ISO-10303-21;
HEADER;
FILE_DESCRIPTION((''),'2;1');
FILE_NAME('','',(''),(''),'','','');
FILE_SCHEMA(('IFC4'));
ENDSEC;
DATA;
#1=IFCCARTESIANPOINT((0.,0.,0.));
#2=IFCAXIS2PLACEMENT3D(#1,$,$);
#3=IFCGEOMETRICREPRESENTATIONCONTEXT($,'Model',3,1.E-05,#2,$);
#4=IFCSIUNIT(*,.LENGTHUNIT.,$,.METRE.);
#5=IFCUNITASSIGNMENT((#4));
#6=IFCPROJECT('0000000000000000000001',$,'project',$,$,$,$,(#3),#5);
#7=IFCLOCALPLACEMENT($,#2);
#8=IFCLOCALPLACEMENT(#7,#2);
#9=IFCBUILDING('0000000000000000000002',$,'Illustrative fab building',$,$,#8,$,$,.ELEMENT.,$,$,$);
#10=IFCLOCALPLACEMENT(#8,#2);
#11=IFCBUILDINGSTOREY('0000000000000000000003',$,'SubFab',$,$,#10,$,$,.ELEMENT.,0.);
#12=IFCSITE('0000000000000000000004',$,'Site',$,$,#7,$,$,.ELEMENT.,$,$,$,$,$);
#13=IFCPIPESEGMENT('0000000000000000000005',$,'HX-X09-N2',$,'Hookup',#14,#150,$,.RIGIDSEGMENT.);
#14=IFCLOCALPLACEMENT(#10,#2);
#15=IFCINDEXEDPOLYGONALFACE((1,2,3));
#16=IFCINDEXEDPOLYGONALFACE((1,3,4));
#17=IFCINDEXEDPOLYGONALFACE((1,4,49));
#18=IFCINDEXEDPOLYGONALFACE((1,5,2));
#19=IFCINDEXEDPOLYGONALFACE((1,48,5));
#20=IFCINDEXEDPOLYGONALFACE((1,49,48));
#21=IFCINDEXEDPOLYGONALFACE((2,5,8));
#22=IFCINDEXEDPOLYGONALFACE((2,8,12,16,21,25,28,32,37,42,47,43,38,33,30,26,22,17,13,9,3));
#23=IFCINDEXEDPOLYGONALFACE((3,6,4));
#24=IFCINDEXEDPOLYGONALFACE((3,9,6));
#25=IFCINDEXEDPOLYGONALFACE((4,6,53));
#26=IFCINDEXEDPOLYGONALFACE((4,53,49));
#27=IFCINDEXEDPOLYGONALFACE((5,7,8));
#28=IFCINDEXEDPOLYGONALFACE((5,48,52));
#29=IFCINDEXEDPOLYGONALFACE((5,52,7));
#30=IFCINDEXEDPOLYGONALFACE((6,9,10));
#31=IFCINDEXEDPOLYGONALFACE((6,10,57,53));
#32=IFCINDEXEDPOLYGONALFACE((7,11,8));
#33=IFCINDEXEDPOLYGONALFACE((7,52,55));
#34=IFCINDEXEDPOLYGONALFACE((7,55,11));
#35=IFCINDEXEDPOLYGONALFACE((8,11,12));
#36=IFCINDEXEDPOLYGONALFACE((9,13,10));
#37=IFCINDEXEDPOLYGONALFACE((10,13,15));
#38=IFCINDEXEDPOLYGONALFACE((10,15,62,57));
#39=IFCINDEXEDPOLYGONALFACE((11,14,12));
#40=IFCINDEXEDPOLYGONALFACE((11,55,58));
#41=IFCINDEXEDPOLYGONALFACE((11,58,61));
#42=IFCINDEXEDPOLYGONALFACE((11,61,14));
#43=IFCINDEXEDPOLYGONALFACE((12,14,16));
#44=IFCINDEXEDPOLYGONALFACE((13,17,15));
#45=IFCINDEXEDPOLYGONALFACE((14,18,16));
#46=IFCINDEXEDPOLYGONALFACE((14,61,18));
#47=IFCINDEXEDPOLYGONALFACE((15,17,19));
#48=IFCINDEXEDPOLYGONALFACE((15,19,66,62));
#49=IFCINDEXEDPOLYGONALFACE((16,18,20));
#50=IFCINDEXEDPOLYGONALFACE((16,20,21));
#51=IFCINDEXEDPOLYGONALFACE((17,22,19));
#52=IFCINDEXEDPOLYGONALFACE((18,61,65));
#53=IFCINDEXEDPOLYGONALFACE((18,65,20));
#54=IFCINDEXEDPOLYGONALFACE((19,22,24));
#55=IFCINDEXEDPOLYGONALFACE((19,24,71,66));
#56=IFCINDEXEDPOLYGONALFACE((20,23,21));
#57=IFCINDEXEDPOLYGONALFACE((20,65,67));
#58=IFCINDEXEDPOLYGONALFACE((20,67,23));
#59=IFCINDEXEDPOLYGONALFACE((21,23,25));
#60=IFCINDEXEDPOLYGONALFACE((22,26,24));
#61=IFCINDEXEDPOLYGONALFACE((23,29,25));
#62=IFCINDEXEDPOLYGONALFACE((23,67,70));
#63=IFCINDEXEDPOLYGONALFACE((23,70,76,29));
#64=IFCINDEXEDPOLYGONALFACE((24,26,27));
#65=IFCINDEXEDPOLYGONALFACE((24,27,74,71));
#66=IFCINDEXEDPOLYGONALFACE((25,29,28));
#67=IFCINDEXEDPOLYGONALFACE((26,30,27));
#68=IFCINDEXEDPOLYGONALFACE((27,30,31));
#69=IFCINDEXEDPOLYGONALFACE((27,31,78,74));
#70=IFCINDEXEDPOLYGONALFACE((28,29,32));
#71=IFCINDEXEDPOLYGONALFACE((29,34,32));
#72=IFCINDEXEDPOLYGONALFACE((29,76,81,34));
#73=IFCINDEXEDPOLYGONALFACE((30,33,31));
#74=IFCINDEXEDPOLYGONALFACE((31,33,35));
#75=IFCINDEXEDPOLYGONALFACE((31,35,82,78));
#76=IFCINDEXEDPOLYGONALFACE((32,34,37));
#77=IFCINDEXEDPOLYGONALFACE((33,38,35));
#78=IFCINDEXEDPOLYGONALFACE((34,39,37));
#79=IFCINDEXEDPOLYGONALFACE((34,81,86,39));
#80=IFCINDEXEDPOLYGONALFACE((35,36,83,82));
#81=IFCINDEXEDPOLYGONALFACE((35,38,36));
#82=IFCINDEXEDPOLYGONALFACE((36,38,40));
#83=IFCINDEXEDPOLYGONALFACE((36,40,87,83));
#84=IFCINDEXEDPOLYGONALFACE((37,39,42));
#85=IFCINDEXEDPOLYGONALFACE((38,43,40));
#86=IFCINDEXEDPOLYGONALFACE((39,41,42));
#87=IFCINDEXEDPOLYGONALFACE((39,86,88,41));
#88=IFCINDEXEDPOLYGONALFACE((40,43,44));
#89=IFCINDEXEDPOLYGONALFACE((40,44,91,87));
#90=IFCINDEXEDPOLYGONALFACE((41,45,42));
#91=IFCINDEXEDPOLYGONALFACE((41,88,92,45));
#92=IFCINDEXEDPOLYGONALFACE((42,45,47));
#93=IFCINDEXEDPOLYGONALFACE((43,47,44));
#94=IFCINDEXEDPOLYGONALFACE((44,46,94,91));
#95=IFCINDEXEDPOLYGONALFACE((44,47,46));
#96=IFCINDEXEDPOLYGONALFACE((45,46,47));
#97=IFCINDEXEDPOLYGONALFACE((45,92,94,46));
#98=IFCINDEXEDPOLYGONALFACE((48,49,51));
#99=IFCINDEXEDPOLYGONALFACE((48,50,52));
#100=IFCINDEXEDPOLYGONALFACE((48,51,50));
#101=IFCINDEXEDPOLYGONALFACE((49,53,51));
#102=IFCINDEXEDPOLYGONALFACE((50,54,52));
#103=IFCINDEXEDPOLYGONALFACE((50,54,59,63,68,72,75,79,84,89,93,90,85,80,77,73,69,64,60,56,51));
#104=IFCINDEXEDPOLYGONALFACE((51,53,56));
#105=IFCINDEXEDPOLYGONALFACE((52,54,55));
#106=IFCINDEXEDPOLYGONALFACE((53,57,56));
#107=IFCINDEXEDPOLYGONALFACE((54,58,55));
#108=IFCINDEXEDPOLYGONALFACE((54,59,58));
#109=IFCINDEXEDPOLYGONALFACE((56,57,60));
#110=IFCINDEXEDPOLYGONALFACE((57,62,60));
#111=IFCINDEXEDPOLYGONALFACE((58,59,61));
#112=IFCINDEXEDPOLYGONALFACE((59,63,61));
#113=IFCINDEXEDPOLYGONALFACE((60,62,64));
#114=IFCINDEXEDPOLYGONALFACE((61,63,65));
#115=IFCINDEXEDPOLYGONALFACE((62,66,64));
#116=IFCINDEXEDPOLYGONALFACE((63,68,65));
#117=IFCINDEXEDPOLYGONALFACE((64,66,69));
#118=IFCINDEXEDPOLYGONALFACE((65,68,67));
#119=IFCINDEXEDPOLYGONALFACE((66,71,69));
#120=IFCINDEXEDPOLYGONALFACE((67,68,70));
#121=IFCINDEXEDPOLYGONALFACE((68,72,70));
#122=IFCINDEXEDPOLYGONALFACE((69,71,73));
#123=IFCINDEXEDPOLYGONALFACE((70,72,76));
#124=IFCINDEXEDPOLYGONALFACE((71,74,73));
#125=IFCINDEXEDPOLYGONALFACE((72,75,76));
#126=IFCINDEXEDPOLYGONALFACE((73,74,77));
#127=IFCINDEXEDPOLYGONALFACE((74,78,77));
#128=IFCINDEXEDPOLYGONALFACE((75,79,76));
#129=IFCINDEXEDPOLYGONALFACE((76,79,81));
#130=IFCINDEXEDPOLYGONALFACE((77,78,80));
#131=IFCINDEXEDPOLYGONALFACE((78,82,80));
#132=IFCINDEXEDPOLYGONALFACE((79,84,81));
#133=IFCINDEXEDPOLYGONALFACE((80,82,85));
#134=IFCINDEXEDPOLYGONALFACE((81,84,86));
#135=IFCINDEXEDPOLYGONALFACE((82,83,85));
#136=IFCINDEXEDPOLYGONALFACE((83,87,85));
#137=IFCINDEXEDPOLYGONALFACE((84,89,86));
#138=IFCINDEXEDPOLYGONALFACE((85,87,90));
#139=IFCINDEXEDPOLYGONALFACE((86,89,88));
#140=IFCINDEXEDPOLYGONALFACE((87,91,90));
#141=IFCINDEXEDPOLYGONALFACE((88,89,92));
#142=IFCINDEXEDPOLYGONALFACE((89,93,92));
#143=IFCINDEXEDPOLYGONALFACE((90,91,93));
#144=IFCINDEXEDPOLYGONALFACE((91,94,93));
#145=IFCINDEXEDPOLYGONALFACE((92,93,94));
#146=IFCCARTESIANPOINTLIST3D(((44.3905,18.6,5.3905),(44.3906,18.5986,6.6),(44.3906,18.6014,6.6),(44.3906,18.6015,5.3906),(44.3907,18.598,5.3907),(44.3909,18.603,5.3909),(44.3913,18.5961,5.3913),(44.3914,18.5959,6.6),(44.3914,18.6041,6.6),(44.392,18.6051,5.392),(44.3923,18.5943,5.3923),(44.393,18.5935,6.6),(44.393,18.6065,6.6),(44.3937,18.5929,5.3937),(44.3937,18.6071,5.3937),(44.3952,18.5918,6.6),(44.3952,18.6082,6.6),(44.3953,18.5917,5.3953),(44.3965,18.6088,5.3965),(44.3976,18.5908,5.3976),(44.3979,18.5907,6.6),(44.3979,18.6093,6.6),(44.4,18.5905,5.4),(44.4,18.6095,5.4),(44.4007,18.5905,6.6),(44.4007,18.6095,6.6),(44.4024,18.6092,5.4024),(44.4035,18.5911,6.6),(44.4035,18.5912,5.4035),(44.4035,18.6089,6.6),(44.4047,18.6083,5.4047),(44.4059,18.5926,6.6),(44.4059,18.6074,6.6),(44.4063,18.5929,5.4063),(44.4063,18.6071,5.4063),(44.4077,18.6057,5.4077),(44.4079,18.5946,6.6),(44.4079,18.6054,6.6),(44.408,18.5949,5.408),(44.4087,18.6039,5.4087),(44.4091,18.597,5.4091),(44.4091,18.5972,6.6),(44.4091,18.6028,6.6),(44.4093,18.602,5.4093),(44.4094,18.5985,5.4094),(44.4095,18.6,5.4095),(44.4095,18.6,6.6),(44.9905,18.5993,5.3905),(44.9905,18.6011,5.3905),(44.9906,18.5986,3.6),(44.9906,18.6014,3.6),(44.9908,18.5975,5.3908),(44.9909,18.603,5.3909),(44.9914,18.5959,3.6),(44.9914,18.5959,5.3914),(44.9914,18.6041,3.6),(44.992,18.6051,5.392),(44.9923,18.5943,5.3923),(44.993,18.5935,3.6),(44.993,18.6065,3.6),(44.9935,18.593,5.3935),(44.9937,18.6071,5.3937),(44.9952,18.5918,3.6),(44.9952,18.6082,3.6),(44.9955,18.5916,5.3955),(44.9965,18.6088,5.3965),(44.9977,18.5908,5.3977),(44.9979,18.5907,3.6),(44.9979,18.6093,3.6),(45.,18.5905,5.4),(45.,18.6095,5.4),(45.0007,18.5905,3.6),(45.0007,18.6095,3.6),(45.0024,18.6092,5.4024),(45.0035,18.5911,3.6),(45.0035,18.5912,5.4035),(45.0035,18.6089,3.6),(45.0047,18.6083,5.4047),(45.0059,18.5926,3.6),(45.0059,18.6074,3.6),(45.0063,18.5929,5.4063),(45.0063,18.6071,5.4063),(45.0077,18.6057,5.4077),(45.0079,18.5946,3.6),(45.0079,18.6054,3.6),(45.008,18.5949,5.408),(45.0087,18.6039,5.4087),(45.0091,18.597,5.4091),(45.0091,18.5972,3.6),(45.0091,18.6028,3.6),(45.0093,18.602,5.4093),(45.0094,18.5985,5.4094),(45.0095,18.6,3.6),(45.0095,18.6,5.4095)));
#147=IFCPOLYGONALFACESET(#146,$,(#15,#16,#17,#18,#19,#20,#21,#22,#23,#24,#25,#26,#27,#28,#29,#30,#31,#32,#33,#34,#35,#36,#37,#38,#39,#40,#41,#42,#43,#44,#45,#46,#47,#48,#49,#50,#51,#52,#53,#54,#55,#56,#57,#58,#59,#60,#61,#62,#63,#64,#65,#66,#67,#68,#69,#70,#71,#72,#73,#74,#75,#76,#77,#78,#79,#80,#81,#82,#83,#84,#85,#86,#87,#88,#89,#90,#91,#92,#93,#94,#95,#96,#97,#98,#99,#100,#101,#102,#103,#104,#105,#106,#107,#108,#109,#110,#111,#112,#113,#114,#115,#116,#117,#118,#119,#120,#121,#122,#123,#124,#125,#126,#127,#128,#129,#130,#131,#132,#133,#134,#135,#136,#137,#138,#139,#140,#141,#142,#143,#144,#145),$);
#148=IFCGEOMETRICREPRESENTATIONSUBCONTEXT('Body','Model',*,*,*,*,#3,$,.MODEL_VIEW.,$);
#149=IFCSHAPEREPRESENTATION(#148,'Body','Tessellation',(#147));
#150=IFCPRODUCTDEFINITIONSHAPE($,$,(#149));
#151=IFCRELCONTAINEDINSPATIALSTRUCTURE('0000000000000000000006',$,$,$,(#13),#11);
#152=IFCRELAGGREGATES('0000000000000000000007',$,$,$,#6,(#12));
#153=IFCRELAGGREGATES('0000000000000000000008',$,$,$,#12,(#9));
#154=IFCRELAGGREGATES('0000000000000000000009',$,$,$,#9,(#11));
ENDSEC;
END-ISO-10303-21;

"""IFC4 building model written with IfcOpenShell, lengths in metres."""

from ifc_helpers import new_model, entity, si_unit, origin, place, context, subcontext, project, spatial, element, save


model = new_model("IFC4")

# Units and contexts
model_context = context("Model", 3, precision=1e-05, world=origin())
body_context = subcontext(model_context, "Body", "Model", "MODEL_VIEW")
ifc_project = project(units=[si_unit("LENGTHUNIT", "METRE")], contexts=[model_context])

# Site, building, storey
site_placement = place(None, origin())
site = spatial("IfcSite", under=ifc_project, at=site_placement, Name="Site", CompositionType="ELEMENT")
building_placement = place(site_placement, origin())
building = spatial("IfcBuilding", under=site, at=building_placement, Name="Illustrative fab building", CompositionType="ELEMENT")
storey_placement = place(building_placement, origin())
storey = spatial("IfcBuildingStorey", under=building, at=storey_placement, Name="SubFab", CompositionType="ELEMENT", Elevation=0.0)

# Pipe segment
pipe_segment_1_placement = place(storey_placement, origin())
element("IfcPipeSegment", 1, at=pipe_segment_1_placement, inside=storey, Name="HX-X09-N2", ObjectType="Hookup", PredefinedType="RIGIDSEGMENT", context=body_context, shape_type="AdvancedSweptSolid", body=[
    entity("IfcSweptDiskSolid", entity("IfcPolyline", [entity("IfcCartesianPoint", [45.0, 18.6, 3.6]), entity("IfcCartesianPoint", [45.0, 18.6, 5.4]), entity("IfcCartesianPoint", [44.4, 18.6, 5.4]), entity("IfcCartesianPoint", [44.4, 18.6, 6.6])]), 0.0095),
])

save(model, "model.ifc")
